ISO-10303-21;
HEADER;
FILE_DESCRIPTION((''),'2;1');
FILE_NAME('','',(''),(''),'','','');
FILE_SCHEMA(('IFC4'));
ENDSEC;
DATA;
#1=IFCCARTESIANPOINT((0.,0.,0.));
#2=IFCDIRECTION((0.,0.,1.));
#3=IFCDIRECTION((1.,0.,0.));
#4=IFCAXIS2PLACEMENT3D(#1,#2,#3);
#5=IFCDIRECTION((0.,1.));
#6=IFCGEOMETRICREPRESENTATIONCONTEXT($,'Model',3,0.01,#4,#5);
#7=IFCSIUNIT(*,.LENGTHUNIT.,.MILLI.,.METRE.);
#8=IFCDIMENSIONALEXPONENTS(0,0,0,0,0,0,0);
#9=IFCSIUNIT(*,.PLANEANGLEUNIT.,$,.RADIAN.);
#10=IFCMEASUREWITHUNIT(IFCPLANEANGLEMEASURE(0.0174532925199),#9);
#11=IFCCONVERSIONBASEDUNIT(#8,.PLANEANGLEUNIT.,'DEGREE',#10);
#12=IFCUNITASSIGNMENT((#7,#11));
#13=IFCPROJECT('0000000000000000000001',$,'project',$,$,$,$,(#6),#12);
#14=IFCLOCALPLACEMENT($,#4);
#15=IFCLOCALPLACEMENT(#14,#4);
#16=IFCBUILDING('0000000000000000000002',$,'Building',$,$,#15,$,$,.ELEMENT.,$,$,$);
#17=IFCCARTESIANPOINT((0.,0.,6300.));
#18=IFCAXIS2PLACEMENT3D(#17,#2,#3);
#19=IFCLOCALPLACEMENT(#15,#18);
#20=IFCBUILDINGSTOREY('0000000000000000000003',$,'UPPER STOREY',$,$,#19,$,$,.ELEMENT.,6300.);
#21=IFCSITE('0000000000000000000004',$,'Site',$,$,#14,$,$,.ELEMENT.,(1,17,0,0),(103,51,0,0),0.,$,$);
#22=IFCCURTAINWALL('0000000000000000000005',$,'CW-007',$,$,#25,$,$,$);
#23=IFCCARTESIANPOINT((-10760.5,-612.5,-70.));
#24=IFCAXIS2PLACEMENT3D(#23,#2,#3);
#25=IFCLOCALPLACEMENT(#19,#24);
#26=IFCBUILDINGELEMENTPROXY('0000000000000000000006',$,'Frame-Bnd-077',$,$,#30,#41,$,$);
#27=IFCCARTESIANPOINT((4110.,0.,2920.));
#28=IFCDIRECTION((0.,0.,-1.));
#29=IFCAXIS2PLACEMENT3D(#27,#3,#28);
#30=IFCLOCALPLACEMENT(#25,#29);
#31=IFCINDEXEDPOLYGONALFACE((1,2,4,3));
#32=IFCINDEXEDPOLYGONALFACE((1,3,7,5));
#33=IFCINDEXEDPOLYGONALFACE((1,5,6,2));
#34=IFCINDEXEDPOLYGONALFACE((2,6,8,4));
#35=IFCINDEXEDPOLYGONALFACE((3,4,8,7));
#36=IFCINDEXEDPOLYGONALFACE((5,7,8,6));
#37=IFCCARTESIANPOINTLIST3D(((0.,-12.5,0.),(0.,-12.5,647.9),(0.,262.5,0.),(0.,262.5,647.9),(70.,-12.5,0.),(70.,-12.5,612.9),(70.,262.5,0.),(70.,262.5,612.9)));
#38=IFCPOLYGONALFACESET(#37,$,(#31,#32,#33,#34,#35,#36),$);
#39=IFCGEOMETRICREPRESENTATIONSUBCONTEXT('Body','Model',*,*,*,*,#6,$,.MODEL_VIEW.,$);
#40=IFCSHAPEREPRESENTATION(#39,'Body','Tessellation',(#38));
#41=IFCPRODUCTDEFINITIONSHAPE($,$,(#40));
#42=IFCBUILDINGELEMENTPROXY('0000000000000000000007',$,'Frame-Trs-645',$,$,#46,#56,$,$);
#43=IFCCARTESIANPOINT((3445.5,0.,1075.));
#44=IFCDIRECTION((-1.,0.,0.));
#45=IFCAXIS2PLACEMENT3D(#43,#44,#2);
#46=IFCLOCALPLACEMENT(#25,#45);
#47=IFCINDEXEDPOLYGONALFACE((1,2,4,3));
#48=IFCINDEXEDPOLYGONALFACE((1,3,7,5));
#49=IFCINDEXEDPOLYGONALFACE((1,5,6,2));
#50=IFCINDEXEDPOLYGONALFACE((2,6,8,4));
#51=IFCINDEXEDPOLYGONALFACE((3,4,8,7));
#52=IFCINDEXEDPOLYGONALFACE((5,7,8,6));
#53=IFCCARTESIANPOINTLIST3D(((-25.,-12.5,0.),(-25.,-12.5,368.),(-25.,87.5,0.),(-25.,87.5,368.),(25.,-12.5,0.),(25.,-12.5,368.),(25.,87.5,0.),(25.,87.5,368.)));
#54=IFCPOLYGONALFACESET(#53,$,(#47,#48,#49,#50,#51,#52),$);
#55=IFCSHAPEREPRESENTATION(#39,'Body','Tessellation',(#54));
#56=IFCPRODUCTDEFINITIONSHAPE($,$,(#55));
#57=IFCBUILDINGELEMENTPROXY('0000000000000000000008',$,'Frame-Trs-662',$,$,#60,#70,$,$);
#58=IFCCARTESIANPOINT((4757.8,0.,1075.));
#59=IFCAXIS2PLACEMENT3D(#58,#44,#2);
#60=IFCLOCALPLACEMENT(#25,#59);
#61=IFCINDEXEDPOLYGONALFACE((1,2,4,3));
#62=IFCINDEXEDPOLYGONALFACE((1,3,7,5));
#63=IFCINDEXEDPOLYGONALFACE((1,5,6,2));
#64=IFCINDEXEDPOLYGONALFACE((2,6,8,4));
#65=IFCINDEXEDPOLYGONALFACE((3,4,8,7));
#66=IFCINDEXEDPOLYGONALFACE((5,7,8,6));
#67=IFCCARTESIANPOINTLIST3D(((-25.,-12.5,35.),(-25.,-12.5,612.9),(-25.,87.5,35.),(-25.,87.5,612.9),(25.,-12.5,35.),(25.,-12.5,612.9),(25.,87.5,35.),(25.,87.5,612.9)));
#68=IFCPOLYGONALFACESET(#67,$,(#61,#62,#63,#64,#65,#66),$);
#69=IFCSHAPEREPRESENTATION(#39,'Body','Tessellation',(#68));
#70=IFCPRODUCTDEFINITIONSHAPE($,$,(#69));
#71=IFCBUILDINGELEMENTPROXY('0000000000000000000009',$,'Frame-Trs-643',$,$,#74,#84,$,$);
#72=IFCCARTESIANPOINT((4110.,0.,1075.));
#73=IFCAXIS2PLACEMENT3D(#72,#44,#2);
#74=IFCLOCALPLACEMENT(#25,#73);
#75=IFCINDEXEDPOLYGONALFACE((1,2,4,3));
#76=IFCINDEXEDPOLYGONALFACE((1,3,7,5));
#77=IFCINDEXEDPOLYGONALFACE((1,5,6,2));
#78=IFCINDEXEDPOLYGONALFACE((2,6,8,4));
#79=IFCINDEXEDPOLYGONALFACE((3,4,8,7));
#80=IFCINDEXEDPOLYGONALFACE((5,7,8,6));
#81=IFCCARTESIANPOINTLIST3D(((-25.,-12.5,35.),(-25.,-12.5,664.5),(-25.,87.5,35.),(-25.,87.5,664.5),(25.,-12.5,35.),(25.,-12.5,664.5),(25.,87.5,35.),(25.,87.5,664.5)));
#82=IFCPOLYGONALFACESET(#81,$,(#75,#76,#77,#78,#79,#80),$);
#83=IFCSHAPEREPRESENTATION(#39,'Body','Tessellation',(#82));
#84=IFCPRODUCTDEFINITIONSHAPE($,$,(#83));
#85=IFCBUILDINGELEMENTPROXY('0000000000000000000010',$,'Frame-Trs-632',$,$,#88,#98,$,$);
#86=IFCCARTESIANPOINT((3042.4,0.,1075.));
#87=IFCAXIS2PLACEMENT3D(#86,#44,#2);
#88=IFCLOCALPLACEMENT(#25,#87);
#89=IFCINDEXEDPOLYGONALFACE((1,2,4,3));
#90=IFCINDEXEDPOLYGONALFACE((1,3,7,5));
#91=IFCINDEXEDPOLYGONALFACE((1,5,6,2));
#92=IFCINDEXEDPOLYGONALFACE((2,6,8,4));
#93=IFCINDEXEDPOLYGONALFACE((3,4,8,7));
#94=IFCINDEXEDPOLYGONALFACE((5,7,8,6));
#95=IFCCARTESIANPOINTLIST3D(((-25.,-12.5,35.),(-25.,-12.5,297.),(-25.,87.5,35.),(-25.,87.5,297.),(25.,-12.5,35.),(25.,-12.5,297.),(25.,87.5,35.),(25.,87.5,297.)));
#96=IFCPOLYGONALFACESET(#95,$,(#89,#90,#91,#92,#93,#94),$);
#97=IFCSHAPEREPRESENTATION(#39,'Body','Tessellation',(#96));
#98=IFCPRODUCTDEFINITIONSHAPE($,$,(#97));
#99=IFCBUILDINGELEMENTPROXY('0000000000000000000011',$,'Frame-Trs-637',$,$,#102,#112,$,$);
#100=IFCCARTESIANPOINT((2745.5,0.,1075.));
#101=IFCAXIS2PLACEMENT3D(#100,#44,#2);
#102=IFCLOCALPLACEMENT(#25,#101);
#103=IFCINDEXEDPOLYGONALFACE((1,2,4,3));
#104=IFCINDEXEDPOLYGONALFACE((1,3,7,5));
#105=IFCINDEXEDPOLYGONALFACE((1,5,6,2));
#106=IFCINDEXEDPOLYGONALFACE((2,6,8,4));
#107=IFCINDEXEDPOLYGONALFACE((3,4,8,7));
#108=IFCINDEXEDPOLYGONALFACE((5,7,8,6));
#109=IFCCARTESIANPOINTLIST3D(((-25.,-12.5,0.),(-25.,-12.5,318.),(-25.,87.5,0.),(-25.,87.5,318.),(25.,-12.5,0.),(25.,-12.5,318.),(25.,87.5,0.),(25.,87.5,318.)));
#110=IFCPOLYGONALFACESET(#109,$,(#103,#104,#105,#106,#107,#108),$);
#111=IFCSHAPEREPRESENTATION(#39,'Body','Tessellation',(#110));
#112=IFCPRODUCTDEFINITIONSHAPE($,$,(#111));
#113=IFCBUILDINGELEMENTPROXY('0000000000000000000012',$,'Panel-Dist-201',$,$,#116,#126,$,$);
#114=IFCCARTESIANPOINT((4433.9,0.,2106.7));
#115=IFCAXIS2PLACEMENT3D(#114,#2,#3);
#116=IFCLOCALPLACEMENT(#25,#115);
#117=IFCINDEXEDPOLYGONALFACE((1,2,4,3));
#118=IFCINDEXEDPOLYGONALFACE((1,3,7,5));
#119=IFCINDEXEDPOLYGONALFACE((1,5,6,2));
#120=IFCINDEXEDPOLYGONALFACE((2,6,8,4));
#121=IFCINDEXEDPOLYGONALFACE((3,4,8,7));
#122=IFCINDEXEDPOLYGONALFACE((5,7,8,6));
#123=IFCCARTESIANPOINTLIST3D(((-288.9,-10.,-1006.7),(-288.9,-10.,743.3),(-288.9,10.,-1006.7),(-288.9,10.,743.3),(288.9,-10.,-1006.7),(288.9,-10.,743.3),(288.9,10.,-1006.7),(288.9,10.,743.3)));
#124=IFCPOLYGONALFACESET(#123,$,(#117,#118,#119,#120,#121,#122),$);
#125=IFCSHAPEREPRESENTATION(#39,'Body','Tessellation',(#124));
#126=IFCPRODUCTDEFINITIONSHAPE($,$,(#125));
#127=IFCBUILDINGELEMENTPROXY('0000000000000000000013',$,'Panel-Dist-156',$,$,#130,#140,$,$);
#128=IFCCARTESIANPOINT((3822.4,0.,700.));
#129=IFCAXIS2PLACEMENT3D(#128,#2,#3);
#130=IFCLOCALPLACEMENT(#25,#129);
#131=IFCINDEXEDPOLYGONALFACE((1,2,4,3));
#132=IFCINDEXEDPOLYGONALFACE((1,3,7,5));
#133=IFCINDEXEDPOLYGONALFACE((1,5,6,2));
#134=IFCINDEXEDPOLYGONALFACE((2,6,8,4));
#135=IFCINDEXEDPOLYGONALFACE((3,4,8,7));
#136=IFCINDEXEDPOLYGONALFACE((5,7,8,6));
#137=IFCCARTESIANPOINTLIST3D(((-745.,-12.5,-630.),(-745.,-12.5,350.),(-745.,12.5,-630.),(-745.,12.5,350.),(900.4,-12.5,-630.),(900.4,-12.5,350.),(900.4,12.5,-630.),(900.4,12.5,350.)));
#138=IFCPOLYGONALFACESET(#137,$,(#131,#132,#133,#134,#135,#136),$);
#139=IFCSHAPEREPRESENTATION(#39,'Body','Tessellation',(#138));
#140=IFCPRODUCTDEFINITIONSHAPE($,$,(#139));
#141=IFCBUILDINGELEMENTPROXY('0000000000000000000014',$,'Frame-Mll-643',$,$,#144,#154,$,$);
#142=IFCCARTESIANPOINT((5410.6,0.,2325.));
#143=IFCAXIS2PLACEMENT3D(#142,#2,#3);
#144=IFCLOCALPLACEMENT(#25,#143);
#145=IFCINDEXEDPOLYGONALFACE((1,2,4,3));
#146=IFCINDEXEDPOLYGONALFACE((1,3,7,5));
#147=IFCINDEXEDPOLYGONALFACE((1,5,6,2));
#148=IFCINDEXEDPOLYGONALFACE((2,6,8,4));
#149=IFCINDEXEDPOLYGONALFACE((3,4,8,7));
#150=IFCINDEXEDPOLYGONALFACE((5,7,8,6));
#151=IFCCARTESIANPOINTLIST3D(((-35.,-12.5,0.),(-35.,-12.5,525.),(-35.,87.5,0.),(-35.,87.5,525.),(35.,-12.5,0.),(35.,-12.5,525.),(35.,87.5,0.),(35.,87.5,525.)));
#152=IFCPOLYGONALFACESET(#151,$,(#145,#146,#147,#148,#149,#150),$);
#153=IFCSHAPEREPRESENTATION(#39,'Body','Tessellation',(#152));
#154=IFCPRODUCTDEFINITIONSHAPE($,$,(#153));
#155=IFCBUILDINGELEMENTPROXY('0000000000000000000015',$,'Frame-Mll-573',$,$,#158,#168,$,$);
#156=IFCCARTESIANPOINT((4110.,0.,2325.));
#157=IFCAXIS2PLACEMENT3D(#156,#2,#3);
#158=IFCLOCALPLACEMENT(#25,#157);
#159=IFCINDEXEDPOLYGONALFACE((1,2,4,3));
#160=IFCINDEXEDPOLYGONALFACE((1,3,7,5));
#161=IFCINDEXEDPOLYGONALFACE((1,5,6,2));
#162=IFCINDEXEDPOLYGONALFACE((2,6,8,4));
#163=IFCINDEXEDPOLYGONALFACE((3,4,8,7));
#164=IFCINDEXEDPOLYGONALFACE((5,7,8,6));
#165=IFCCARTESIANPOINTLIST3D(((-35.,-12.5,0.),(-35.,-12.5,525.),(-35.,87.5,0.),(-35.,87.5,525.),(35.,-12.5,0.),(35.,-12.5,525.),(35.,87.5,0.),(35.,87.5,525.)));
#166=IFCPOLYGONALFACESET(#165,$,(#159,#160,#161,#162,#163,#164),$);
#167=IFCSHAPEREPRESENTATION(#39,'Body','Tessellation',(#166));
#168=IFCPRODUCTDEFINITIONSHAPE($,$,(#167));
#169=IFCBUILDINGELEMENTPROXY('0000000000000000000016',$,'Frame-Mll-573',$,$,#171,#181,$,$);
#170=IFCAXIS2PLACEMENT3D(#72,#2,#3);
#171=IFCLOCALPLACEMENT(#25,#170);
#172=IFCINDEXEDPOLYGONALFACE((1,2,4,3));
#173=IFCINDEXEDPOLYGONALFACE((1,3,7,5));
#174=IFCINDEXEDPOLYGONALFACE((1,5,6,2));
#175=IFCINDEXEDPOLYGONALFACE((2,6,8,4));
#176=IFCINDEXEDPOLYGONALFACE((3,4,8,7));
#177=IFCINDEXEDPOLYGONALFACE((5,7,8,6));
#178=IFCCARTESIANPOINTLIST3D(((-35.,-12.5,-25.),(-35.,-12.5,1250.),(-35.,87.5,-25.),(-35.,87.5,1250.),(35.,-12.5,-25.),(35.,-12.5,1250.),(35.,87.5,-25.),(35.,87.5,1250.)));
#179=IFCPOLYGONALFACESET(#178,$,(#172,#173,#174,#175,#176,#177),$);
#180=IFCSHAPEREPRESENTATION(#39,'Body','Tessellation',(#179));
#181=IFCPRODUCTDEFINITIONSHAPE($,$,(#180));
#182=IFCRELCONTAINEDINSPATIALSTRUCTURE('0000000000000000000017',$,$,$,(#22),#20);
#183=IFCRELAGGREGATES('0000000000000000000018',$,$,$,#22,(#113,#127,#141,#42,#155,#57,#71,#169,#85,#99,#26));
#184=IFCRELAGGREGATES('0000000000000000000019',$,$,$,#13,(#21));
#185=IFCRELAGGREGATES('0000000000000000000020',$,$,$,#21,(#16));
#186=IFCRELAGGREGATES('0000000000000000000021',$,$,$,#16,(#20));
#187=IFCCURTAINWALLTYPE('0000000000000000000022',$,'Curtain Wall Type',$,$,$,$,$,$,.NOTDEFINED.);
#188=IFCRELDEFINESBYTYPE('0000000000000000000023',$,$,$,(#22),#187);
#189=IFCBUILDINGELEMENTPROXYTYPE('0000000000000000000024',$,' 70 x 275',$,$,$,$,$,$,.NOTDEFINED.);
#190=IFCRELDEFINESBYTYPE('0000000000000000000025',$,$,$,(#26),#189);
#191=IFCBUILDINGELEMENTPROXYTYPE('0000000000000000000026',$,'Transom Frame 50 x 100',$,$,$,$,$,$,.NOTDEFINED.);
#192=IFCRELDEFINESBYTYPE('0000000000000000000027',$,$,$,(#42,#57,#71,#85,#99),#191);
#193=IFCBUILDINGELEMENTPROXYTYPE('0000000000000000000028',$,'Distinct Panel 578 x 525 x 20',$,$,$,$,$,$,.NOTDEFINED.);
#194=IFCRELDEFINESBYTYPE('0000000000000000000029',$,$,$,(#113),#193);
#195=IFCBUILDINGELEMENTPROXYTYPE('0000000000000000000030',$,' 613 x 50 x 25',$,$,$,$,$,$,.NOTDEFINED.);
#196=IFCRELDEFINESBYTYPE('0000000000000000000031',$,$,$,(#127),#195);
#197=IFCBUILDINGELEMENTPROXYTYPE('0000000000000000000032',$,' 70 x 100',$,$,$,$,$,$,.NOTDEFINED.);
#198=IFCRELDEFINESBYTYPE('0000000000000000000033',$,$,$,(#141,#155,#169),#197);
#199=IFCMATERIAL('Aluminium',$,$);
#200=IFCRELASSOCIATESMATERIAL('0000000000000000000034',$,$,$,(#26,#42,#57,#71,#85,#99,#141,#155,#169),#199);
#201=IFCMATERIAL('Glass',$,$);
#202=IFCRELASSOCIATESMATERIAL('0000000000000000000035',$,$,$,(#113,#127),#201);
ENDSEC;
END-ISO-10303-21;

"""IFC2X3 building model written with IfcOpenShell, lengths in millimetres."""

from ifc_helpers import new_model, entity, si_unit, converted_unit, direction, frame, origin_with_axes, place, context, subcontext, project, spatial, polyline, outline, extrude, clip, halfspace, material, type_object, element, aggregate, save


model = new_model("IFC2X3")

# Units and contexts
model_context = context("Model", 3, precision=0.01, world=origin_with_axes(), true_north=direction((0.0, 1.0)))
body_context = subcontext(model_context, "Body", "Model", "MODEL_VIEW")
ifc_project = project(units=[si_unit("LENGTHUNIT", "METRE", prefix="MILLI"), converted_unit("PLANEANGLEUNIT", "DEGREE", entity("IfcPlaneAngleMeasure", 0.0174532925199), si_unit("PLANEANGLEUNIT", "RADIAN"), dimensions=[0, 0, 0, 0, 0, 0, 0])], contexts=[model_context])

# Site, building, storey
site_placement = place(None, origin_with_axes())
site = spatial("IfcSite", under=ifc_project, at=site_placement, Name="Site", CompositionType="ELEMENT", RefLatitude=(1, 17, 0, 0), RefLongitude=(103, 51, 0, 0), RefElevation=0.0)
building_placement = place(site_placement, origin_with_axes())
building = spatial("IfcBuilding", under=site, at=building_placement, Name="Building", CompositionType="ELEMENT")
storey_placement = place(building_placement, frame((0.0, 0.0, 6300.0), z_axis=(0.0, 0.0, 1.0), x_axis=(1.0, 0.0, 0.0)))
storey = spatial("IfcBuildingStorey", under=building, at=storey_placement, Name="UPPER STOREY", CompositionType="ELEMENT", Elevation=6300.0)

# Curtain wall, building element proxies
curtain_wall_type = type_object("IfcCurtainWallType", Name="Curtain Wall Type", PredefinedType="NOTDEFINED")
curtain_wall_placement = place(storey_placement, frame((-10760.5, -612.5, -70.0), z_axis=(0.0, 0.0, 1.0), x_axis=(1.0, 0.0, 0.0)))
curtain_wall = element("IfcCurtainWall", 1, at=curtain_wall_placement, inside=storey, type_object=curtain_wall_type, Name="CW-007")
ifc_material_1 = material(Name="Aluminium")
building_element_proxy_type_1 = type_object("IfcBuildingElementProxyType", Name=" 70 x 275", PredefinedType="NOTDEFINED")
proxy_1_placement = place(curtain_wall_placement, frame((4110.0, 0.0, 2920.0), z_axis=(1.0, 0.0, 0.0), x_axis=(0.0, 0.0, -1.0)))
proxy_1 = element("IfcBuildingElementProxy", 2, at=proxy_1_placement, type_object=building_element_proxy_type_1, material=ifc_material_1, Name="Frame-Bnd-077", context=body_context, shape_type="Clipping", body=[
    clip(extrude(outline(polyline([(-262.5, 70.0), (-262.5, 0.0), (12.5, 0.0), (12.5, 70.0), (-262.5, 70.0)])), frame((0.0, 0.0, 0.0), z_axis=(0.0, 0.0, 1.0), x_axis=(0.0, -1.0, 0.0)), (0.0, 0.0, 1.0), 647.9), halfspace(frame((259.2, 0.0, 518.3), z_axis=(-0.447214, 0.0, -0.894427), x_axis=(0.0, 1.0, 0.0)), True)),
])
building_element_proxy_type_2 = type_object("IfcBuildingElementProxyType", Name="Transom Frame 50 x 100", PredefinedType="NOTDEFINED")
proxy_2_placement = place(curtain_wall_placement, frame((3445.5, 0.0, 1075.0), z_axis=(-1.0, 0.0, 0.0), x_axis=(0.0, 0.0, 1.0)))
proxy_2 = element("IfcBuildingElementProxy", 3, at=proxy_2_placement, type_object=building_element_proxy_type_2, material=ifc_material_1, Name="Frame-Trs-645", context=body_context, shape_type="SweptSolid", body=[
    extrude(outline(polyline([(87.5, -25.0), (87.5, 25.0), (-12.5, 25.0), (-12.5, -25.0), (87.5, -25.0)])), frame((0.0, 0.0, 0.0), z_axis=(0.0, 0.0, 1.0), x_axis=(0.0, 1.0, 0.0)), (0.0, 0.0, 1.0), 368.0),
])
proxy_3_placement = place(curtain_wall_placement, frame((4757.8, 0.0, 1075.0), z_axis=(-1.0, 0.0, 0.0), x_axis=(0.0, 0.0, 1.0)))
proxy_3 = element("IfcBuildingElementProxy", 4, at=proxy_3_placement, type_object=building_element_proxy_type_2, material=ifc_material_1, Name="Frame-Trs-662", context=body_context, shape_type="SweptSolid", body=[
    extrude(outline(polyline([(87.5, -25.0), (87.5, 25.0), (-12.5, 25.0), (-12.5, -25.0), (87.5, -25.0)])), frame((0.0, 0.0, 35.0), z_axis=(0.0, 0.0, 1.0), x_axis=(0.0, 1.0, 0.0)), (0.0, 0.0, 1.0), 577.9),
])
proxy_4_placement = place(curtain_wall_placement, frame((4110.0, 0.0, 1075.0), z_axis=(-1.0, 0.0, 0.0), x_axis=(0.0, 0.0, 1.0)))
proxy_4 = element("IfcBuildingElementProxy", 5, at=proxy_4_placement, type_object=building_element_proxy_type_2, material=ifc_material_1, Name="Frame-Trs-643", context=body_context, shape_type="SweptSolid", body=[
    extrude(outline(polyline([(87.5, -25.0), (87.5, 25.0), (-12.5, 25.0), (-12.5, -25.0), (87.5, -25.0)])), frame((0.0, 0.0, 35.0), z_axis=(0.0, 0.0, 1.0), x_axis=(0.0, 1.0, 0.0)), (0.0, 0.0, 1.0), 629.5),
])
proxy_5_placement = place(curtain_wall_placement, frame((3042.4, 0.0, 1075.0), z_axis=(-1.0, 0.0, 0.0), x_axis=(0.0, 0.0, 1.0)))
proxy_5 = element("IfcBuildingElementProxy", 6, at=proxy_5_placement, type_object=building_element_proxy_type_2, material=ifc_material_1, Name="Frame-Trs-632", context=body_context, shape_type="SweptSolid", body=[
    extrude(outline(polyline([(87.5, -25.0), (87.5, 25.0), (-12.5, 25.0), (-12.5, -25.0), (87.5, -25.0)])), frame((0.0, 0.0, 35.0), z_axis=(0.0, 0.0, 1.0), x_axis=(0.0, 1.0, 0.0)), (0.0, 0.0, 1.0), 262.0),
])
proxy_6_placement = place(curtain_wall_placement, frame((2745.5, 0.0, 1075.0), z_axis=(-1.0, 0.0, 0.0), x_axis=(0.0, 0.0, 1.0)))
proxy_6 = element("IfcBuildingElementProxy", 7, at=proxy_6_placement, type_object=building_element_proxy_type_2, material=ifc_material_1, Name="Frame-Trs-637", context=body_context, shape_type="SweptSolid", body=[
    extrude(outline(polyline([(87.5, -25.0), (87.5, 25.0), (-12.5, 25.0), (-12.5, -25.0), (87.5, -25.0)])), frame((0.0, 0.0, 0.0), z_axis=(0.0, 0.0, 1.0), x_axis=(0.0, 1.0, 0.0)), (0.0, 0.0, 1.0), 318.0),
])
ifc_material_2 = material(Name="Glass")
building_element_proxy_type_3 = type_object("IfcBuildingElementProxyType", Name="Distinct Panel 578 x 525 x 20", PredefinedType="NOTDEFINED")
proxy_7_placement = place(curtain_wall_placement, frame((4433.9, 0.0, 2106.7), z_axis=(0.0, 0.0, 1.0), x_axis=(1.0, 0.0, 0.0)))
proxy_7 = element("IfcBuildingElementProxy", 8, at=proxy_7_placement, type_object=building_element_proxy_type_3, material=ifc_material_2, Name="Panel-Dist-201", context=body_context, shape_type="SweptSolid", body=[
    extrude(outline(polyline([(-288.9, -743.3), (288.9, -743.3), (288.9, 1006.7), (-288.9, 1006.7), (-288.9, -743.3)])), frame((0.0, -10.0, 0.0), z_axis=(0.0, 1.0, 0.0), x_axis=(1.0, 0.0, 0.0)), (0.0, 0.0, 1.0), 20.0),
])
building_element_proxy_type_4 = type_object("IfcBuildingElementProxyType", Name=" 613 x 50 x 25", PredefinedType="NOTDEFINED")
proxy_8_placement = place(curtain_wall_placement, frame((3822.4, 0.0, 700.0), z_axis=(0.0, 0.0, 1.0), x_axis=(1.0, 0.0, 0.0)))
proxy_8 = element("IfcBuildingElementProxy", 9, at=proxy_8_placement, type_object=building_element_proxy_type_4, material=ifc_material_2, Name="Panel-Dist-156", context=body_context, shape_type="SweptSolid", body=[
    extrude(outline(polyline([(-745.0, -350.0), (900.4, -350.0), (900.4, 630.0), (-745.0, 630.0), (-745.0, -350.0)])), frame((0.0, -12.5, 0.0), z_axis=(0.0, 1.0, 0.0), x_axis=(1.0, 0.0, 0.0)), (0.0, 0.0, 1.0), 25.0),
])
building_element_proxy_type_5 = type_object("IfcBuildingElementProxyType", Name=" 70 x 100", PredefinedType="NOTDEFINED")
proxy_9_placement = place(curtain_wall_placement, frame((5410.6, 0.0, 2325.0), z_axis=(0.0, 0.0, 1.0), x_axis=(1.0, 0.0, 0.0)))
proxy_9 = element("IfcBuildingElementProxy", 10, at=proxy_9_placement, type_object=building_element_proxy_type_5, material=ifc_material_1, Name="Frame-Mll-643", context=body_context, shape_type="SweptSolid", body=[
    extrude(outline(polyline([(35.0, 87.5), (-35.0, 87.5), (-35.0, -12.5), (35.0, -12.5), (35.0, 87.5)])), frame((0.0, 0.0, 0.0), z_axis=(0.0, 0.0, 1.0), x_axis=(1.0, 0.0, 0.0)), (0.0, 0.0, 1.0), 525.0),
])
proxy_10_placement = place(curtain_wall_placement, frame((4110.0, 0.0, 2325.0), z_axis=(0.0, 0.0, 1.0), x_axis=(1.0, 0.0, 0.0)))
proxy_10 = element("IfcBuildingElementProxy", 11, at=proxy_10_placement, type_object=building_element_proxy_type_5, material=ifc_material_1, Name="Frame-Mll-573", context=body_context, shape_type="SweptSolid", body=[
    extrude(outline(polyline([(35.0, 87.5), (-35.0, 87.5), (-35.0, -12.5), (35.0, -12.5), (35.0, 87.5)])), frame((0.0, 0.0, 0.0), z_axis=(0.0, 0.0, 1.0), x_axis=(1.0, 0.0, 0.0)), (0.0, 0.0, 1.0), 525.0),
])
proxy_11_placement = place(curtain_wall_placement, frame((4110.0, 0.0, 1075.0), z_axis=(0.0, 0.0, 1.0), x_axis=(1.0, 0.0, 0.0)))
proxy_11 = element("IfcBuildingElementProxy", 12, at=proxy_11_placement, type_object=building_element_proxy_type_5, material=ifc_material_1, Name="Frame-Mll-573", context=body_context, shape_type="SweptSolid", body=[
    extrude(outline(polyline([(35.0, 87.5), (-35.0, 87.5), (-35.0, -12.5), (35.0, -12.5), (35.0, 87.5)])), frame((0.0, 0.0, -25.0), z_axis=(0.0, 0.0, 1.0), x_axis=(1.0, 0.0, 0.0)), (0.0, 0.0, 1.0), 1275.0),
])
aggregate(curtain_wall, [proxy_7, proxy_8, proxy_9, proxy_2, proxy_10, proxy_3, proxy_4, proxy_11, proxy_5, proxy_6, proxy_1])

save(model, "model.ifc")
